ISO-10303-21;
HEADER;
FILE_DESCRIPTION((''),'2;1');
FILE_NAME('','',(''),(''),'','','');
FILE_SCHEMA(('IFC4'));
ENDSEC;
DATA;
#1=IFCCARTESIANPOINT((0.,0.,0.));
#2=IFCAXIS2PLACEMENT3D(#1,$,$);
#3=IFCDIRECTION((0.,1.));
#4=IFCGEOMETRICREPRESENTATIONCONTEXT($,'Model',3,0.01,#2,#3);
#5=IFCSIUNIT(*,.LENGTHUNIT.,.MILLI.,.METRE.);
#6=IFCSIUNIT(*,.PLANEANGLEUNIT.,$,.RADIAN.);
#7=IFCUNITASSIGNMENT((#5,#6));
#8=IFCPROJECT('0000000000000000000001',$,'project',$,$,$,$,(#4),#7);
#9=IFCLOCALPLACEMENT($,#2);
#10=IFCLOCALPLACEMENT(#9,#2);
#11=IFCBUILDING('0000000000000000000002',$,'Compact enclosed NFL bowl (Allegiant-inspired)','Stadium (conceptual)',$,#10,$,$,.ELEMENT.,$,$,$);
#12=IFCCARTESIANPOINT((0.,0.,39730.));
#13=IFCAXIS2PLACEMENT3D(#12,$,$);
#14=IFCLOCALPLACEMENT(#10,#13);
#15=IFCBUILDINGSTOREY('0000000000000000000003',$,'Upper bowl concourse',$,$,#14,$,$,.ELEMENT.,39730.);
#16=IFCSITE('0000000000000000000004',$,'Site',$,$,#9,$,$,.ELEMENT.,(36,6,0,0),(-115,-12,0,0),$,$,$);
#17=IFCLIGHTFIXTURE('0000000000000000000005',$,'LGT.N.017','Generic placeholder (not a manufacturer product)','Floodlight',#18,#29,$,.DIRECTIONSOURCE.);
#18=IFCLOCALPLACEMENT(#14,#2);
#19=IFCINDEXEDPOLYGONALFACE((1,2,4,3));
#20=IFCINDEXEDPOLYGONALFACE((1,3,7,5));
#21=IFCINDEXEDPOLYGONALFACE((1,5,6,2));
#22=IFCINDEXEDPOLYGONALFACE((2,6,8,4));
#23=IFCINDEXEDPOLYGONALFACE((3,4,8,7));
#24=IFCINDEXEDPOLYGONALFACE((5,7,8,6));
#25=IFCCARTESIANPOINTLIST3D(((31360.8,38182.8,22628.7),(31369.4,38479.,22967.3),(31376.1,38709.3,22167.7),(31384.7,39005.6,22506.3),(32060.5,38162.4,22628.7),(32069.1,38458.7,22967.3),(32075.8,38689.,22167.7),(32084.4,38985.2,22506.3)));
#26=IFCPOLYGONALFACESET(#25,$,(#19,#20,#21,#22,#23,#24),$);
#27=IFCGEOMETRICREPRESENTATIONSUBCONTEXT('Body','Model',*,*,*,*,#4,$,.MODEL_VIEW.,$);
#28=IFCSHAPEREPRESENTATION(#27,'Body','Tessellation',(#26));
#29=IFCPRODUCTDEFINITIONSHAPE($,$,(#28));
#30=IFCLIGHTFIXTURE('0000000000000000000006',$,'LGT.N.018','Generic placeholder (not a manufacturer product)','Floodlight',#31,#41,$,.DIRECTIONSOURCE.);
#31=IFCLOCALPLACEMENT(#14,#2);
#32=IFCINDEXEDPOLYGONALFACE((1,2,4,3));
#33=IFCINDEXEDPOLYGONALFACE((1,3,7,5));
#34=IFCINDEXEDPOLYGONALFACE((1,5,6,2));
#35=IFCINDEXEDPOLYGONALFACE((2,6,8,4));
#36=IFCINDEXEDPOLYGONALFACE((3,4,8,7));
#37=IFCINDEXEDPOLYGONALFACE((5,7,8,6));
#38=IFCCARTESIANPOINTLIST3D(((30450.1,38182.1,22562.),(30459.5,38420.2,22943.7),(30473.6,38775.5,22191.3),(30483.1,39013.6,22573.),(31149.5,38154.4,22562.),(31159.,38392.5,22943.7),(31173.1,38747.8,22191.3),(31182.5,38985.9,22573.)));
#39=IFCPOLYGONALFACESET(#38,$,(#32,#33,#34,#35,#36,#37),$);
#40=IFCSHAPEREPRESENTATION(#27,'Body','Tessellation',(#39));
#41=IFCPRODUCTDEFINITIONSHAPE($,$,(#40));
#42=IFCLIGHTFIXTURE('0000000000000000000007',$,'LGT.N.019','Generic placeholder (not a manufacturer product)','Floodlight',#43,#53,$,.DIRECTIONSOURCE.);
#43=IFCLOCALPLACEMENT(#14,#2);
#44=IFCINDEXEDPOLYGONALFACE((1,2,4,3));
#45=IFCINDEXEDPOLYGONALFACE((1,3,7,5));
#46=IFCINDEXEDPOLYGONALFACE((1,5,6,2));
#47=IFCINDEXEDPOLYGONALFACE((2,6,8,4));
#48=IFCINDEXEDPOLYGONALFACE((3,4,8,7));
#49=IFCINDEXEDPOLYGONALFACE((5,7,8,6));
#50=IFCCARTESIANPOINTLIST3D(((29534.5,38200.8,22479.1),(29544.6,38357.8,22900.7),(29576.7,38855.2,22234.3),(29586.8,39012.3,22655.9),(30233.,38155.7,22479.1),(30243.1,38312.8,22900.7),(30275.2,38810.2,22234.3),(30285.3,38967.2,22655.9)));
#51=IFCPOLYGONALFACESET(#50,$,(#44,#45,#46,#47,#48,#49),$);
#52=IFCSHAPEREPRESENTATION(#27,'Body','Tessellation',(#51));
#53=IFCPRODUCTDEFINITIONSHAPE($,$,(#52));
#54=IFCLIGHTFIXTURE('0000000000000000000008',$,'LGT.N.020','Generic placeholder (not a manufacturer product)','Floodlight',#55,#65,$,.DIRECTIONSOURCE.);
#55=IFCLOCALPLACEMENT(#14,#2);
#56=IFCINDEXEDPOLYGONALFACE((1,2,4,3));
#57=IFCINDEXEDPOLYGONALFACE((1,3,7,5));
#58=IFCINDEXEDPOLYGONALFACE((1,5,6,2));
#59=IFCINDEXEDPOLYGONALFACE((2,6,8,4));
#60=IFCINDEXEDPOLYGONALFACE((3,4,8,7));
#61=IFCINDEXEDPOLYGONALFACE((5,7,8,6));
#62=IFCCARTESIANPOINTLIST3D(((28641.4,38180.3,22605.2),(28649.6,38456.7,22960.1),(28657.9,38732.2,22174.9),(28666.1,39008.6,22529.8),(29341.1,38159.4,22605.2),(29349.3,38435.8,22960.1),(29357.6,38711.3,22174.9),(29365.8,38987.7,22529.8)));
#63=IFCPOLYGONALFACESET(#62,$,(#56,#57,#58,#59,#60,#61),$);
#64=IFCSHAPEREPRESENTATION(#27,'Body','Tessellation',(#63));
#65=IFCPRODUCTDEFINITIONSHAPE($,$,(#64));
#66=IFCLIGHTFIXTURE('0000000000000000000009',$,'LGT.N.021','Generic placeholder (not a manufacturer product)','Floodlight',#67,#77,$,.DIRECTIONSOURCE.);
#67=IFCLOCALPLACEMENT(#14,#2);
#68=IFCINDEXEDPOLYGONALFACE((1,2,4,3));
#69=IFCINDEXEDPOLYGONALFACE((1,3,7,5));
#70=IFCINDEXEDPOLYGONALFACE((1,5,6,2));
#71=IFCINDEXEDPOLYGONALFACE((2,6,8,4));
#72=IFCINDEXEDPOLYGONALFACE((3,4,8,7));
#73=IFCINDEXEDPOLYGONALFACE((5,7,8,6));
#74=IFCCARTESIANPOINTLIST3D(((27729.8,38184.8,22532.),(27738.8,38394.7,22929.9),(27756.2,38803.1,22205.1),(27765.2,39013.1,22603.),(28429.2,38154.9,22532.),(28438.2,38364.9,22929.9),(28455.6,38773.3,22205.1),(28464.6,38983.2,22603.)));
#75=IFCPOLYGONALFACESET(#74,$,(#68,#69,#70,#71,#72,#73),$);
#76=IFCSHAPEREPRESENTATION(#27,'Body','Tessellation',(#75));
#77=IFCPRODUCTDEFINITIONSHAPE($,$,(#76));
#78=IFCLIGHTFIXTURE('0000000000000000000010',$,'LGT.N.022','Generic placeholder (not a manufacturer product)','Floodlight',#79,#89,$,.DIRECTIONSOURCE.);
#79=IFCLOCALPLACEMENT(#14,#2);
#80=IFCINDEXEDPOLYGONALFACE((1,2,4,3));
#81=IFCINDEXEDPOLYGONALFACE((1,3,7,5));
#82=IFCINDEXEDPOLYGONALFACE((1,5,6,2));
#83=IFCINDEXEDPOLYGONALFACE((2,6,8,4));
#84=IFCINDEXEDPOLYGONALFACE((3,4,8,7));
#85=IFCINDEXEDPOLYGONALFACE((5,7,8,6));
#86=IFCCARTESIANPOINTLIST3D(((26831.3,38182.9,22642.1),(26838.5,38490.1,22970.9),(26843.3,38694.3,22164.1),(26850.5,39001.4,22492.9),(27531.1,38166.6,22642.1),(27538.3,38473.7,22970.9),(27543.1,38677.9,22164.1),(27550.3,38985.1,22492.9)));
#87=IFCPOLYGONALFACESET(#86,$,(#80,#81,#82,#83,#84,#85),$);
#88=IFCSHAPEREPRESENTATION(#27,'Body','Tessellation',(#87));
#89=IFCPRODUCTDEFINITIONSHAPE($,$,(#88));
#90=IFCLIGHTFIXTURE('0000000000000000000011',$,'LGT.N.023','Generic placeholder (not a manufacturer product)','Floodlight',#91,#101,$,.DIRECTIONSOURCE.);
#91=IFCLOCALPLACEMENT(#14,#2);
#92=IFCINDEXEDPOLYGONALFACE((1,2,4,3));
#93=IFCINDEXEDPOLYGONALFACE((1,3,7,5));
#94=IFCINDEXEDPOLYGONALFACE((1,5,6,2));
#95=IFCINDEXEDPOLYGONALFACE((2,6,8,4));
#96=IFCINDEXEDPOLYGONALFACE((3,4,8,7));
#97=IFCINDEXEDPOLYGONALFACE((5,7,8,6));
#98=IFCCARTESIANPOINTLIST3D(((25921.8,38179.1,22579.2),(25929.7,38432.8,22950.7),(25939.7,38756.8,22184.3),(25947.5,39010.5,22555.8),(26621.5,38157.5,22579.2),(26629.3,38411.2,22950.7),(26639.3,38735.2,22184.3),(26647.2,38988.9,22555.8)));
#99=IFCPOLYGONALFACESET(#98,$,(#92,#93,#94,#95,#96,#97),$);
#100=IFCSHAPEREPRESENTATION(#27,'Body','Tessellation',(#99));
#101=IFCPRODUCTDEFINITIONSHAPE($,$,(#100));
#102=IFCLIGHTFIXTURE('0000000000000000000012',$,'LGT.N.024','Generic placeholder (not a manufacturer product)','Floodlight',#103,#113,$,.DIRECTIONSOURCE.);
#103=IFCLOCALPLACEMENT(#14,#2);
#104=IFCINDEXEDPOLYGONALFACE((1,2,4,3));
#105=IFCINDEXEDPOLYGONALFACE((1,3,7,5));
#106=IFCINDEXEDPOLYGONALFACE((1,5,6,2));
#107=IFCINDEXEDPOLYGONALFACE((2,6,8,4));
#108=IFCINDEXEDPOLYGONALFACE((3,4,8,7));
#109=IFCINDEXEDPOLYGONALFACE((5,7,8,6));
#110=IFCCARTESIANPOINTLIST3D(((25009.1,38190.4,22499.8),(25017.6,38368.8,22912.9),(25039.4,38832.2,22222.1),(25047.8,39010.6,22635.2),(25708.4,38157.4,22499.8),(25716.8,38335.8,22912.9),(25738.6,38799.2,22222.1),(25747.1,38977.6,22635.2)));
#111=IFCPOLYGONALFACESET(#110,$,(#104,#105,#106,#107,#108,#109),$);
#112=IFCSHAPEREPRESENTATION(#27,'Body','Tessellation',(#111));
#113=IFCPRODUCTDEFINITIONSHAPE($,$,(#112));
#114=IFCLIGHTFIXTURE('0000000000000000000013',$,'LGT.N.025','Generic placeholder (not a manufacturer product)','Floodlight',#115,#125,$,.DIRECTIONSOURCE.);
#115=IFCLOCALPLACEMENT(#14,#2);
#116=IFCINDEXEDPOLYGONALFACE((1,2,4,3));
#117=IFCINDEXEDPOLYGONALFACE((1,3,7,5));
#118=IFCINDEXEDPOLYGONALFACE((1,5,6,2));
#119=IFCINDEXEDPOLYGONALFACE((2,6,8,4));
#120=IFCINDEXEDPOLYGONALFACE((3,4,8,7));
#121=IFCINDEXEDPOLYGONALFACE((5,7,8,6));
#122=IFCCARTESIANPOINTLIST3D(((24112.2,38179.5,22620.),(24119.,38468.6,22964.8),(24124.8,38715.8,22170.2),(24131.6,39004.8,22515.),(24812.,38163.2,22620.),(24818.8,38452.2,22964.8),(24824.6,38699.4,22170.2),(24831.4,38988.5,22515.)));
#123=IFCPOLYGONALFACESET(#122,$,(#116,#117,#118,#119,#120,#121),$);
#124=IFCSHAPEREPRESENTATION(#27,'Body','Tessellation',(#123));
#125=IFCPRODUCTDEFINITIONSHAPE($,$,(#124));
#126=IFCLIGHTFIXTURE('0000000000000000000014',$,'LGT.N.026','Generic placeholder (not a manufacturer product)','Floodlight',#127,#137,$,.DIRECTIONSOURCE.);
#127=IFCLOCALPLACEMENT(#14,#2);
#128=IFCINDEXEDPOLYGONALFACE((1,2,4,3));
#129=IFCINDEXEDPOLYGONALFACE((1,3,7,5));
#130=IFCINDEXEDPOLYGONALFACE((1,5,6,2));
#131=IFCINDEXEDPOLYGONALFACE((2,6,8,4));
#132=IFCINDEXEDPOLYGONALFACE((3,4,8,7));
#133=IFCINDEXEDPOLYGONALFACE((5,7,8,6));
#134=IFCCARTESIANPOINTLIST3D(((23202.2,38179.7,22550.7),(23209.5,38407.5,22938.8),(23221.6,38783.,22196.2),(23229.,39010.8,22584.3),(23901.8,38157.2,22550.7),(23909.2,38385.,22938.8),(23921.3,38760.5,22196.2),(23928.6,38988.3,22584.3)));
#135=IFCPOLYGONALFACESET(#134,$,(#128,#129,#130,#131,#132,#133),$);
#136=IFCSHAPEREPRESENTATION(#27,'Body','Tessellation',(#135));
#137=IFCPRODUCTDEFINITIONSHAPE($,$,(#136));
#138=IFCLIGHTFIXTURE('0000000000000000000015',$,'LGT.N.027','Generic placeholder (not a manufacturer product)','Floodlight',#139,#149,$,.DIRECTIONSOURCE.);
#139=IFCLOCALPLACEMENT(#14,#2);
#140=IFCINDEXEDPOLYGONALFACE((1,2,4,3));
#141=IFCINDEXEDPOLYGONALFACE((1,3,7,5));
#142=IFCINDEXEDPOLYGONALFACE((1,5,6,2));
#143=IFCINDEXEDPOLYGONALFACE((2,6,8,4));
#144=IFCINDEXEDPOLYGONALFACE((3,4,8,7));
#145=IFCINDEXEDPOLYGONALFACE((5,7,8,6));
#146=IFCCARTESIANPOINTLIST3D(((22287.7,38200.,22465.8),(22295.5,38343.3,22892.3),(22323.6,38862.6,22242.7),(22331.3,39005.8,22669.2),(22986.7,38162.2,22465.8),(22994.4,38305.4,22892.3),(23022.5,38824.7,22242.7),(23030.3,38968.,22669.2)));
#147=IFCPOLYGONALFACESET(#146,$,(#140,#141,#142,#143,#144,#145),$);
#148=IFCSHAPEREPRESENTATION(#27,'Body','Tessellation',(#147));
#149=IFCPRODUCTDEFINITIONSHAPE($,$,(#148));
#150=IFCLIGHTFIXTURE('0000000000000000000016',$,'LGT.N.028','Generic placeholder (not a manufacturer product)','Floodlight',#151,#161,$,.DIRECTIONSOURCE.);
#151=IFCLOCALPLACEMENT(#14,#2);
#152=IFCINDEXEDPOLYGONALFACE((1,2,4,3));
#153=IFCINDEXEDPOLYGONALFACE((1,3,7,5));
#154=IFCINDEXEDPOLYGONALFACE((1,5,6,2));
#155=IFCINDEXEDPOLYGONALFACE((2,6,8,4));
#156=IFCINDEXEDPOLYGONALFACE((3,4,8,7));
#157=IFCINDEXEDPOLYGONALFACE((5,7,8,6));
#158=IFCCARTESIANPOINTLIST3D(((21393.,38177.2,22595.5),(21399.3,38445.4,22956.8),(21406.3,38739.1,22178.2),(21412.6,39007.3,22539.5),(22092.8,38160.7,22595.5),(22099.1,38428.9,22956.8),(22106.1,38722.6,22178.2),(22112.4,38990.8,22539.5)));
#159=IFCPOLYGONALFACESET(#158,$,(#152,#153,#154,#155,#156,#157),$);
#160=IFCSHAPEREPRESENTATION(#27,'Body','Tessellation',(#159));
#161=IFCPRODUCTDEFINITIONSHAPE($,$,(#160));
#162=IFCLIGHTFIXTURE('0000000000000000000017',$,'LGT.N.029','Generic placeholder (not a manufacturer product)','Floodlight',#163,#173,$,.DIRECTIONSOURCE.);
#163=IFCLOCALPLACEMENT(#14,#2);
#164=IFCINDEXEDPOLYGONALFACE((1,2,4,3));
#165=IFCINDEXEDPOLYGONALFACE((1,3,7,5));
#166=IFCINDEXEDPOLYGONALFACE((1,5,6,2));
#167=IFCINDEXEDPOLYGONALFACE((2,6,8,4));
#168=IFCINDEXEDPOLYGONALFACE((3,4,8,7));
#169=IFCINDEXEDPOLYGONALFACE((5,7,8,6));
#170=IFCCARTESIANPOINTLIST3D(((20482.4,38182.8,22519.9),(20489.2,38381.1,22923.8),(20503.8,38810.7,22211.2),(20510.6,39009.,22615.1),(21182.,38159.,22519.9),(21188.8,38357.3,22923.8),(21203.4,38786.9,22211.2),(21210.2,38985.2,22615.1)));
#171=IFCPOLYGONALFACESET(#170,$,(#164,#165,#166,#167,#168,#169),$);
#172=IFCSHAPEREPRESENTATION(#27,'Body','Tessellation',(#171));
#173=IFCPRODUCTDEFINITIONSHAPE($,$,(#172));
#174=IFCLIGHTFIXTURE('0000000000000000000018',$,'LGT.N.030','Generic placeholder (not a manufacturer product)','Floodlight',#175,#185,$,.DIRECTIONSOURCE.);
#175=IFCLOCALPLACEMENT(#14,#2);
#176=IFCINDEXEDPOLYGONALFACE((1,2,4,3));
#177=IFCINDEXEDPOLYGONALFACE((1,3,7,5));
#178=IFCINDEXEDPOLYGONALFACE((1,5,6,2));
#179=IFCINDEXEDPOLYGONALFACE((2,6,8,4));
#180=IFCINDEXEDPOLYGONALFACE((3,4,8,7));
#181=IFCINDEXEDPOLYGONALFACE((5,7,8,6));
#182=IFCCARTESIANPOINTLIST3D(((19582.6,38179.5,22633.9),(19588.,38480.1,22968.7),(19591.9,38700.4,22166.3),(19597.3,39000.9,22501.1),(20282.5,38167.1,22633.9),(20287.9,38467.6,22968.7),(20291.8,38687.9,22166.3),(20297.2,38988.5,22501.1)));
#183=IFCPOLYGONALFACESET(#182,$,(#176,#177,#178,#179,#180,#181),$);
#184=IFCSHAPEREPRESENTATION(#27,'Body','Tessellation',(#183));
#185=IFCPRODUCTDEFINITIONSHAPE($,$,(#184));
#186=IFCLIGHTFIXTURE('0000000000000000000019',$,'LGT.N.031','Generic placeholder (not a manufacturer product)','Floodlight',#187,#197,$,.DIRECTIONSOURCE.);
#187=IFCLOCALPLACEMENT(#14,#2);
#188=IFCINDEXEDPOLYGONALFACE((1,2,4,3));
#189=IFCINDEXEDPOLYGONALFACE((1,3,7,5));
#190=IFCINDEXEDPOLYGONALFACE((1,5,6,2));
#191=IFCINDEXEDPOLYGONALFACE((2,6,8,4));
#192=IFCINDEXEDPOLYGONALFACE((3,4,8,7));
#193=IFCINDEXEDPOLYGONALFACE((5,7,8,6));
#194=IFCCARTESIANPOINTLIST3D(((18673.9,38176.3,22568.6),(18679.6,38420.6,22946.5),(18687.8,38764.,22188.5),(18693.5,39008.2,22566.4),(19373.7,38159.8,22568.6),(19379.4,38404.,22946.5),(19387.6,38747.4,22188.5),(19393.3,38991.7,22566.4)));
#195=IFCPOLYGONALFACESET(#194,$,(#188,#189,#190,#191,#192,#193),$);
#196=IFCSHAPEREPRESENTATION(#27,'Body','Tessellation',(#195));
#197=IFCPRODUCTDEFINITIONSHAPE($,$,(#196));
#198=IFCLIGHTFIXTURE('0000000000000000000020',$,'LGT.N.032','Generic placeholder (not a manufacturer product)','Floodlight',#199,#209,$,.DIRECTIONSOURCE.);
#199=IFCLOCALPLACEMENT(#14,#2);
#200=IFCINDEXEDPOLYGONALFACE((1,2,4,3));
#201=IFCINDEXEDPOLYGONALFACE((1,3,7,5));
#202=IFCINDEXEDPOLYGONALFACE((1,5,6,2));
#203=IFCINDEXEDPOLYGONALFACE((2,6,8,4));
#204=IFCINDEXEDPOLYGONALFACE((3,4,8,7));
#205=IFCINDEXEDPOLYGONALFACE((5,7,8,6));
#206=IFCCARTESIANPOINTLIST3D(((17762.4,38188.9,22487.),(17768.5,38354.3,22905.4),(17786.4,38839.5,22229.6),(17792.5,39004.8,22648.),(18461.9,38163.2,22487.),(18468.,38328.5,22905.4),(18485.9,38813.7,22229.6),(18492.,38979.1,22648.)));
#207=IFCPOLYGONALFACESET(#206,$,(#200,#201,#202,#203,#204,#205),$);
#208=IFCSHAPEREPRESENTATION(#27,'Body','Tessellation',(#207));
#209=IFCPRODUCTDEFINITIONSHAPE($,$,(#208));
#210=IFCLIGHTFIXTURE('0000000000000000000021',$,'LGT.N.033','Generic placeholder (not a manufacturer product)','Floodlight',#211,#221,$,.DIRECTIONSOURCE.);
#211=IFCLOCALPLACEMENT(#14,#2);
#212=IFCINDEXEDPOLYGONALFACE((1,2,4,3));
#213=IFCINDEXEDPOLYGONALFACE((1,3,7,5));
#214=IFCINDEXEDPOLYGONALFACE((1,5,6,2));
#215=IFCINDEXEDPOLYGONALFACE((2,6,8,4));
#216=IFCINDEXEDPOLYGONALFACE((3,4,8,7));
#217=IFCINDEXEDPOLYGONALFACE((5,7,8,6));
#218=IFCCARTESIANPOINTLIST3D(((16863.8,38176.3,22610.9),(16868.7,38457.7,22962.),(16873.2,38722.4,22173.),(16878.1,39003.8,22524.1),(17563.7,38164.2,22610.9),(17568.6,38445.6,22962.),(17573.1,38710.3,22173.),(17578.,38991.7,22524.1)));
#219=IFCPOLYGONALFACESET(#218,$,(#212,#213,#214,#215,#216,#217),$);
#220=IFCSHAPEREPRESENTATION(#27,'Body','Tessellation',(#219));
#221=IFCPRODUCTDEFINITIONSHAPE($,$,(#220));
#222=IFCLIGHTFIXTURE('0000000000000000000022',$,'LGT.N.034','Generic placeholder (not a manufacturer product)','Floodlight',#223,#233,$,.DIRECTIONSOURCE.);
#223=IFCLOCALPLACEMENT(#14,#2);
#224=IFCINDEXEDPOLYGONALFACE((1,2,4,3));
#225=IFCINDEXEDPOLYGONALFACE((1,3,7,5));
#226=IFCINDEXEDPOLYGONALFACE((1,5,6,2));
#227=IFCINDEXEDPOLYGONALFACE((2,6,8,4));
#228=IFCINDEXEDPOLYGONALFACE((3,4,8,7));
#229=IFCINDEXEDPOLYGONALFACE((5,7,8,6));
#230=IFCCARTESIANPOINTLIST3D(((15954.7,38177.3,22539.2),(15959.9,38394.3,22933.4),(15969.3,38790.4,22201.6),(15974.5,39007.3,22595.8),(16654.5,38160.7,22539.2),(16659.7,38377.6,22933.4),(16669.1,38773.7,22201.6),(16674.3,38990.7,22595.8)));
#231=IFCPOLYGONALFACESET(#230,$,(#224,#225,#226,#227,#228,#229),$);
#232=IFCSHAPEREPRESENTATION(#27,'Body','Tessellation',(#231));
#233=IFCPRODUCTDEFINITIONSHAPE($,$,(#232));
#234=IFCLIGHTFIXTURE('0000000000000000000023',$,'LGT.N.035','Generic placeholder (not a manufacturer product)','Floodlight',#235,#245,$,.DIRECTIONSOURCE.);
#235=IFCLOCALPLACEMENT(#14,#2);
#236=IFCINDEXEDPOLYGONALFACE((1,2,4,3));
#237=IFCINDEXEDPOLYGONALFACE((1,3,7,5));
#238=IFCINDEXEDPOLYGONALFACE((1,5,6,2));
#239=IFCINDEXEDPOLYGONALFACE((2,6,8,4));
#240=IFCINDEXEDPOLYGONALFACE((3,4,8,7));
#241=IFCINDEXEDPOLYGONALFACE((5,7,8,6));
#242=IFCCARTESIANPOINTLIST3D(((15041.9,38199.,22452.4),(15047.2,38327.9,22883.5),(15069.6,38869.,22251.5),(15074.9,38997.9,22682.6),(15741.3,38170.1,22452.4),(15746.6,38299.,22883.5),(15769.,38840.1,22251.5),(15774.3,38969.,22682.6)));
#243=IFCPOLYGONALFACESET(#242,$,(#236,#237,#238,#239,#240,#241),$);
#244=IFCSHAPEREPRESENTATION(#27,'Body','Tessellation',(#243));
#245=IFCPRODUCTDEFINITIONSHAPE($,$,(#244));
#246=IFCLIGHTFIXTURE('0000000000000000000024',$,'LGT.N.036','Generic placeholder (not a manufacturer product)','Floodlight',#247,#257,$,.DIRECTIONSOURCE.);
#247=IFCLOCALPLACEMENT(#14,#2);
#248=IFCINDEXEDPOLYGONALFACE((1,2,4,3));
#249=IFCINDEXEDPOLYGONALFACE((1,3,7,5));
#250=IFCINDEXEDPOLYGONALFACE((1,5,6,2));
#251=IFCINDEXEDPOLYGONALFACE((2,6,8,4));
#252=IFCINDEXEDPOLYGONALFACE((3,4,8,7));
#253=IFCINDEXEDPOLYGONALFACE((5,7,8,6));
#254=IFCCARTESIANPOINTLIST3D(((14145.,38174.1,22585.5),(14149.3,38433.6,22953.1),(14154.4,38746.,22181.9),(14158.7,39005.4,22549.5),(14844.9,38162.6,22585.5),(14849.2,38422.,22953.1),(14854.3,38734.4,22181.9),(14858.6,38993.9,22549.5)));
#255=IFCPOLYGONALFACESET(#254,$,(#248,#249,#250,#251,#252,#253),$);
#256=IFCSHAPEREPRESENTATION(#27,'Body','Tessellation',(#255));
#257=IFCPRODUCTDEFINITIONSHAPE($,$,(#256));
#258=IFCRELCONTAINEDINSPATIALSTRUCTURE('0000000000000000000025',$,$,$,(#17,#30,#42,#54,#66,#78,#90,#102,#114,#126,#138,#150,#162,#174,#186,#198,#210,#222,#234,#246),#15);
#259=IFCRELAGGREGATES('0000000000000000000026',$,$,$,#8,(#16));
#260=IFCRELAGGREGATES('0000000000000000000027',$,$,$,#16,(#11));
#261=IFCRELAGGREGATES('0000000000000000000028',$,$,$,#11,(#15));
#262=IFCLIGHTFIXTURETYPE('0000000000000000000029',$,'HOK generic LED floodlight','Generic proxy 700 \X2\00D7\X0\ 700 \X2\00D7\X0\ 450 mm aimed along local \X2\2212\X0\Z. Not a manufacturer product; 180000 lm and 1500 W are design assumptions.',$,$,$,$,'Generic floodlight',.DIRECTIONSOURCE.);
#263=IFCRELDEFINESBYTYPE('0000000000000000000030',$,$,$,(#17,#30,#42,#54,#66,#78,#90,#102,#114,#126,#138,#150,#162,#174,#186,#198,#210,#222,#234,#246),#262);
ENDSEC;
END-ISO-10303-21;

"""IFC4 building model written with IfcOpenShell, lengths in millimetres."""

from ifc_helpers import new_model, si_unit, direction, frame, origin, place, context, subcontext, project, spatial, rectangle, extrude, source, transform, mapped, type_object, type_shapes, element, save


model = new_model("IFC4")

# Units and contexts
model_context = context("Model", 3, precision=0.01, world=origin(), true_north=direction((0.0, 1.0)))
body_context = subcontext(model_context, "Body", "Model", "MODEL_VIEW")
ifc_project = project(units=[si_unit("LENGTHUNIT", "METRE", prefix="MILLI"), si_unit("PLANEANGLEUNIT", "RADIAN")], contexts=[model_context])

# Site, building, storey
site_placement = place(None, origin())
site = spatial("IfcSite", under=ifc_project, at=site_placement, Name="Site", CompositionType="ELEMENT", RefLatitude=(36, 6, 0, 0), RefLongitude=(-115, -12, 0, 0))
building_placement = place(site_placement, origin())
building = spatial("IfcBuilding", under=site, at=building_placement, Name="Compact enclosed NFL bowl (Allegiant-inspired)", Description="Stadium (conceptual)", CompositionType="ELEMENT")
storey_placement = place(building_placement, frame((0.0, 0.0, 39730.0)))
storey = spatial("IfcBuildingStorey", under=building, at=storey_placement, Name="Upper bowl concourse", CompositionType="ELEMENT", Elevation=39730.0)

# Light fixtures
light_fixture_type = type_object("IfcLightFixtureType", Name="HOK generic LED floodlight", Description="Generic proxy 700 × 700 × 450 mm aimed along local −Z. Not a manufacturer product; 180000 lm and 1500 W are design assumptions.", ElementType="Generic floodlight", PredefinedType="DIRECTIONSOURCE")
shared_shape = source(origin(), body_context, "Body", "SweptSolid", [
    extrude(rectangle(XDim=700.0, YDim=700.0), frame((0.0, 0.0, -225.0)), (0.0, 0.0, 1.0), 450.0),
])
type_shapes(light_fixture_type, [shared_shape])
for number, where, z_axis, x_axis, name in (
    (1, (31722.6, 38584.0, 22567.5), (0.019159, 0.658318, 0.752496), (-0.999577, 0.029091, 0.0), "LGT.N.017"),
    (2, (30816.3, 38584.0, 22567.5), (0.020982, 0.529075, 0.848316), (-0.999215, 0.039626, 0.0), "LGT.N.018"),
    (3, (29909.9, 38584.0, 22567.5), (0.02249, 0.348985, 0.936858), (-0.99793, 0.06431, 0.0), "LGT.N.019"),
    (4, (29003.6, 38584.0, 22567.5), (0.018362, 0.614392, 0.788787), (-0.999554, 0.029872, 0.0), "LGT.N.020"),
    (5, (28097.2, 38584.0, 22567.5), (0.01994, 0.466638, 0.884224), (-0.999088, 0.042692, 0.0), "LGT.N.021"),
    (6, (27190.8, 38584.0, 22567.5), (0.015946, 0.682546, 0.730668), (-0.999727, 0.023356, 0.0), "LGT.N.022"),
    (7, (26284.5, 38584.0, 22567.5), (0.017418, 0.5639, 0.825659), (-0.999523, 0.030874, 0.0), "LGT.N.023"),
    (8, (25378.1, 38584.0, 22567.5), (0.018696, 0.396352, 0.917908), (-0.998889, 0.047119, 0.0), "LGT.N.024"),
    (9, (24471.8, 38584.0, 22567.5), (0.015051, 0.642311, 0.766296), (-0.999726, 0.023426, 0.0), "LGT.N.025"),
    (10, (23565.4, 38584.0, 22567.5), (0.016309, 0.506181, 0.862273), (-0.999481, 0.032202, 0.0), "LGT.N.026"),
    (11, (22659.0, 38584.0, 22567.5), (0.017237, 0.318336, 0.947821), (-0.998537, 0.054069, 0.0), "LGT.N.027"),
    (12, (21752.7, 38584.0, 22567.5), (0.014017, 0.595958, 0.802893), (-0.999723, 0.023514, 0.0), "LGT.N.028"),
    (13, (20846.3, 38584.0, 22567.5), (0.015016, 0.440756, 0.897501), (-0.99942, 0.03405, 0.0), "LGT.N.029"),
    (14, (19939.9, 38584.0, 22567.5), (0.01191, 0.667887, 0.744168), (-0.999841, 0.017829, 0.0), "LGT.N.030"),
    (15, (19033.6, 38584.0, 22567.5), (0.012829, 0.542772, 0.839782), (-0.999721, 0.023629, 0.0), "LGT.N.031"),
    (16, (18127.2, 38584.0, 22567.5), (0.01353, 0.367468, 0.929938), (-0.999323, 0.036793, 0.0), "LGT.N.032"),
    (17, (17220.9, 38584.0, 22567.5), (0.010784, 0.625399, 0.780231), (-0.999851, 0.017241, 0.0), "LGT.N.033"),
    (18, (16314.5, 38584.0, 22567.5), (0.011471, 0.482146, 0.876016), (-0.999717, 0.023784, 0.0), "LGT.N.034"),
    (19, (15408.1, 38584.0, 22567.5), (0.011847, 0.286638, 0.957966), (-0.999147, 0.041295, 0.0), "LGT.N.035"),
    (20, (14501.8, 38584.0, 22567.5), (0.00951, 0.576513, 0.817033), (-0.999864, 0.016493, 0.0), "LGT.N.036"),
):
    element("IfcLightFixture", number, at=place(storey_placement, frame(where, z_axis=z_axis, x_axis=x_axis)), inside=storey, type_object=light_fixture_type, Name=name, Description="Generic placeholder (not a manufacturer product)", ObjectType="Floodlight", PredefinedType="DIRECTIONSOURCE", context=body_context, shape_type="MappedRepresentation", body=[
        mapped(shared_shape, transform((0.0, 0.0, 0.0))),
    ])

save(model, "model.ifc")
